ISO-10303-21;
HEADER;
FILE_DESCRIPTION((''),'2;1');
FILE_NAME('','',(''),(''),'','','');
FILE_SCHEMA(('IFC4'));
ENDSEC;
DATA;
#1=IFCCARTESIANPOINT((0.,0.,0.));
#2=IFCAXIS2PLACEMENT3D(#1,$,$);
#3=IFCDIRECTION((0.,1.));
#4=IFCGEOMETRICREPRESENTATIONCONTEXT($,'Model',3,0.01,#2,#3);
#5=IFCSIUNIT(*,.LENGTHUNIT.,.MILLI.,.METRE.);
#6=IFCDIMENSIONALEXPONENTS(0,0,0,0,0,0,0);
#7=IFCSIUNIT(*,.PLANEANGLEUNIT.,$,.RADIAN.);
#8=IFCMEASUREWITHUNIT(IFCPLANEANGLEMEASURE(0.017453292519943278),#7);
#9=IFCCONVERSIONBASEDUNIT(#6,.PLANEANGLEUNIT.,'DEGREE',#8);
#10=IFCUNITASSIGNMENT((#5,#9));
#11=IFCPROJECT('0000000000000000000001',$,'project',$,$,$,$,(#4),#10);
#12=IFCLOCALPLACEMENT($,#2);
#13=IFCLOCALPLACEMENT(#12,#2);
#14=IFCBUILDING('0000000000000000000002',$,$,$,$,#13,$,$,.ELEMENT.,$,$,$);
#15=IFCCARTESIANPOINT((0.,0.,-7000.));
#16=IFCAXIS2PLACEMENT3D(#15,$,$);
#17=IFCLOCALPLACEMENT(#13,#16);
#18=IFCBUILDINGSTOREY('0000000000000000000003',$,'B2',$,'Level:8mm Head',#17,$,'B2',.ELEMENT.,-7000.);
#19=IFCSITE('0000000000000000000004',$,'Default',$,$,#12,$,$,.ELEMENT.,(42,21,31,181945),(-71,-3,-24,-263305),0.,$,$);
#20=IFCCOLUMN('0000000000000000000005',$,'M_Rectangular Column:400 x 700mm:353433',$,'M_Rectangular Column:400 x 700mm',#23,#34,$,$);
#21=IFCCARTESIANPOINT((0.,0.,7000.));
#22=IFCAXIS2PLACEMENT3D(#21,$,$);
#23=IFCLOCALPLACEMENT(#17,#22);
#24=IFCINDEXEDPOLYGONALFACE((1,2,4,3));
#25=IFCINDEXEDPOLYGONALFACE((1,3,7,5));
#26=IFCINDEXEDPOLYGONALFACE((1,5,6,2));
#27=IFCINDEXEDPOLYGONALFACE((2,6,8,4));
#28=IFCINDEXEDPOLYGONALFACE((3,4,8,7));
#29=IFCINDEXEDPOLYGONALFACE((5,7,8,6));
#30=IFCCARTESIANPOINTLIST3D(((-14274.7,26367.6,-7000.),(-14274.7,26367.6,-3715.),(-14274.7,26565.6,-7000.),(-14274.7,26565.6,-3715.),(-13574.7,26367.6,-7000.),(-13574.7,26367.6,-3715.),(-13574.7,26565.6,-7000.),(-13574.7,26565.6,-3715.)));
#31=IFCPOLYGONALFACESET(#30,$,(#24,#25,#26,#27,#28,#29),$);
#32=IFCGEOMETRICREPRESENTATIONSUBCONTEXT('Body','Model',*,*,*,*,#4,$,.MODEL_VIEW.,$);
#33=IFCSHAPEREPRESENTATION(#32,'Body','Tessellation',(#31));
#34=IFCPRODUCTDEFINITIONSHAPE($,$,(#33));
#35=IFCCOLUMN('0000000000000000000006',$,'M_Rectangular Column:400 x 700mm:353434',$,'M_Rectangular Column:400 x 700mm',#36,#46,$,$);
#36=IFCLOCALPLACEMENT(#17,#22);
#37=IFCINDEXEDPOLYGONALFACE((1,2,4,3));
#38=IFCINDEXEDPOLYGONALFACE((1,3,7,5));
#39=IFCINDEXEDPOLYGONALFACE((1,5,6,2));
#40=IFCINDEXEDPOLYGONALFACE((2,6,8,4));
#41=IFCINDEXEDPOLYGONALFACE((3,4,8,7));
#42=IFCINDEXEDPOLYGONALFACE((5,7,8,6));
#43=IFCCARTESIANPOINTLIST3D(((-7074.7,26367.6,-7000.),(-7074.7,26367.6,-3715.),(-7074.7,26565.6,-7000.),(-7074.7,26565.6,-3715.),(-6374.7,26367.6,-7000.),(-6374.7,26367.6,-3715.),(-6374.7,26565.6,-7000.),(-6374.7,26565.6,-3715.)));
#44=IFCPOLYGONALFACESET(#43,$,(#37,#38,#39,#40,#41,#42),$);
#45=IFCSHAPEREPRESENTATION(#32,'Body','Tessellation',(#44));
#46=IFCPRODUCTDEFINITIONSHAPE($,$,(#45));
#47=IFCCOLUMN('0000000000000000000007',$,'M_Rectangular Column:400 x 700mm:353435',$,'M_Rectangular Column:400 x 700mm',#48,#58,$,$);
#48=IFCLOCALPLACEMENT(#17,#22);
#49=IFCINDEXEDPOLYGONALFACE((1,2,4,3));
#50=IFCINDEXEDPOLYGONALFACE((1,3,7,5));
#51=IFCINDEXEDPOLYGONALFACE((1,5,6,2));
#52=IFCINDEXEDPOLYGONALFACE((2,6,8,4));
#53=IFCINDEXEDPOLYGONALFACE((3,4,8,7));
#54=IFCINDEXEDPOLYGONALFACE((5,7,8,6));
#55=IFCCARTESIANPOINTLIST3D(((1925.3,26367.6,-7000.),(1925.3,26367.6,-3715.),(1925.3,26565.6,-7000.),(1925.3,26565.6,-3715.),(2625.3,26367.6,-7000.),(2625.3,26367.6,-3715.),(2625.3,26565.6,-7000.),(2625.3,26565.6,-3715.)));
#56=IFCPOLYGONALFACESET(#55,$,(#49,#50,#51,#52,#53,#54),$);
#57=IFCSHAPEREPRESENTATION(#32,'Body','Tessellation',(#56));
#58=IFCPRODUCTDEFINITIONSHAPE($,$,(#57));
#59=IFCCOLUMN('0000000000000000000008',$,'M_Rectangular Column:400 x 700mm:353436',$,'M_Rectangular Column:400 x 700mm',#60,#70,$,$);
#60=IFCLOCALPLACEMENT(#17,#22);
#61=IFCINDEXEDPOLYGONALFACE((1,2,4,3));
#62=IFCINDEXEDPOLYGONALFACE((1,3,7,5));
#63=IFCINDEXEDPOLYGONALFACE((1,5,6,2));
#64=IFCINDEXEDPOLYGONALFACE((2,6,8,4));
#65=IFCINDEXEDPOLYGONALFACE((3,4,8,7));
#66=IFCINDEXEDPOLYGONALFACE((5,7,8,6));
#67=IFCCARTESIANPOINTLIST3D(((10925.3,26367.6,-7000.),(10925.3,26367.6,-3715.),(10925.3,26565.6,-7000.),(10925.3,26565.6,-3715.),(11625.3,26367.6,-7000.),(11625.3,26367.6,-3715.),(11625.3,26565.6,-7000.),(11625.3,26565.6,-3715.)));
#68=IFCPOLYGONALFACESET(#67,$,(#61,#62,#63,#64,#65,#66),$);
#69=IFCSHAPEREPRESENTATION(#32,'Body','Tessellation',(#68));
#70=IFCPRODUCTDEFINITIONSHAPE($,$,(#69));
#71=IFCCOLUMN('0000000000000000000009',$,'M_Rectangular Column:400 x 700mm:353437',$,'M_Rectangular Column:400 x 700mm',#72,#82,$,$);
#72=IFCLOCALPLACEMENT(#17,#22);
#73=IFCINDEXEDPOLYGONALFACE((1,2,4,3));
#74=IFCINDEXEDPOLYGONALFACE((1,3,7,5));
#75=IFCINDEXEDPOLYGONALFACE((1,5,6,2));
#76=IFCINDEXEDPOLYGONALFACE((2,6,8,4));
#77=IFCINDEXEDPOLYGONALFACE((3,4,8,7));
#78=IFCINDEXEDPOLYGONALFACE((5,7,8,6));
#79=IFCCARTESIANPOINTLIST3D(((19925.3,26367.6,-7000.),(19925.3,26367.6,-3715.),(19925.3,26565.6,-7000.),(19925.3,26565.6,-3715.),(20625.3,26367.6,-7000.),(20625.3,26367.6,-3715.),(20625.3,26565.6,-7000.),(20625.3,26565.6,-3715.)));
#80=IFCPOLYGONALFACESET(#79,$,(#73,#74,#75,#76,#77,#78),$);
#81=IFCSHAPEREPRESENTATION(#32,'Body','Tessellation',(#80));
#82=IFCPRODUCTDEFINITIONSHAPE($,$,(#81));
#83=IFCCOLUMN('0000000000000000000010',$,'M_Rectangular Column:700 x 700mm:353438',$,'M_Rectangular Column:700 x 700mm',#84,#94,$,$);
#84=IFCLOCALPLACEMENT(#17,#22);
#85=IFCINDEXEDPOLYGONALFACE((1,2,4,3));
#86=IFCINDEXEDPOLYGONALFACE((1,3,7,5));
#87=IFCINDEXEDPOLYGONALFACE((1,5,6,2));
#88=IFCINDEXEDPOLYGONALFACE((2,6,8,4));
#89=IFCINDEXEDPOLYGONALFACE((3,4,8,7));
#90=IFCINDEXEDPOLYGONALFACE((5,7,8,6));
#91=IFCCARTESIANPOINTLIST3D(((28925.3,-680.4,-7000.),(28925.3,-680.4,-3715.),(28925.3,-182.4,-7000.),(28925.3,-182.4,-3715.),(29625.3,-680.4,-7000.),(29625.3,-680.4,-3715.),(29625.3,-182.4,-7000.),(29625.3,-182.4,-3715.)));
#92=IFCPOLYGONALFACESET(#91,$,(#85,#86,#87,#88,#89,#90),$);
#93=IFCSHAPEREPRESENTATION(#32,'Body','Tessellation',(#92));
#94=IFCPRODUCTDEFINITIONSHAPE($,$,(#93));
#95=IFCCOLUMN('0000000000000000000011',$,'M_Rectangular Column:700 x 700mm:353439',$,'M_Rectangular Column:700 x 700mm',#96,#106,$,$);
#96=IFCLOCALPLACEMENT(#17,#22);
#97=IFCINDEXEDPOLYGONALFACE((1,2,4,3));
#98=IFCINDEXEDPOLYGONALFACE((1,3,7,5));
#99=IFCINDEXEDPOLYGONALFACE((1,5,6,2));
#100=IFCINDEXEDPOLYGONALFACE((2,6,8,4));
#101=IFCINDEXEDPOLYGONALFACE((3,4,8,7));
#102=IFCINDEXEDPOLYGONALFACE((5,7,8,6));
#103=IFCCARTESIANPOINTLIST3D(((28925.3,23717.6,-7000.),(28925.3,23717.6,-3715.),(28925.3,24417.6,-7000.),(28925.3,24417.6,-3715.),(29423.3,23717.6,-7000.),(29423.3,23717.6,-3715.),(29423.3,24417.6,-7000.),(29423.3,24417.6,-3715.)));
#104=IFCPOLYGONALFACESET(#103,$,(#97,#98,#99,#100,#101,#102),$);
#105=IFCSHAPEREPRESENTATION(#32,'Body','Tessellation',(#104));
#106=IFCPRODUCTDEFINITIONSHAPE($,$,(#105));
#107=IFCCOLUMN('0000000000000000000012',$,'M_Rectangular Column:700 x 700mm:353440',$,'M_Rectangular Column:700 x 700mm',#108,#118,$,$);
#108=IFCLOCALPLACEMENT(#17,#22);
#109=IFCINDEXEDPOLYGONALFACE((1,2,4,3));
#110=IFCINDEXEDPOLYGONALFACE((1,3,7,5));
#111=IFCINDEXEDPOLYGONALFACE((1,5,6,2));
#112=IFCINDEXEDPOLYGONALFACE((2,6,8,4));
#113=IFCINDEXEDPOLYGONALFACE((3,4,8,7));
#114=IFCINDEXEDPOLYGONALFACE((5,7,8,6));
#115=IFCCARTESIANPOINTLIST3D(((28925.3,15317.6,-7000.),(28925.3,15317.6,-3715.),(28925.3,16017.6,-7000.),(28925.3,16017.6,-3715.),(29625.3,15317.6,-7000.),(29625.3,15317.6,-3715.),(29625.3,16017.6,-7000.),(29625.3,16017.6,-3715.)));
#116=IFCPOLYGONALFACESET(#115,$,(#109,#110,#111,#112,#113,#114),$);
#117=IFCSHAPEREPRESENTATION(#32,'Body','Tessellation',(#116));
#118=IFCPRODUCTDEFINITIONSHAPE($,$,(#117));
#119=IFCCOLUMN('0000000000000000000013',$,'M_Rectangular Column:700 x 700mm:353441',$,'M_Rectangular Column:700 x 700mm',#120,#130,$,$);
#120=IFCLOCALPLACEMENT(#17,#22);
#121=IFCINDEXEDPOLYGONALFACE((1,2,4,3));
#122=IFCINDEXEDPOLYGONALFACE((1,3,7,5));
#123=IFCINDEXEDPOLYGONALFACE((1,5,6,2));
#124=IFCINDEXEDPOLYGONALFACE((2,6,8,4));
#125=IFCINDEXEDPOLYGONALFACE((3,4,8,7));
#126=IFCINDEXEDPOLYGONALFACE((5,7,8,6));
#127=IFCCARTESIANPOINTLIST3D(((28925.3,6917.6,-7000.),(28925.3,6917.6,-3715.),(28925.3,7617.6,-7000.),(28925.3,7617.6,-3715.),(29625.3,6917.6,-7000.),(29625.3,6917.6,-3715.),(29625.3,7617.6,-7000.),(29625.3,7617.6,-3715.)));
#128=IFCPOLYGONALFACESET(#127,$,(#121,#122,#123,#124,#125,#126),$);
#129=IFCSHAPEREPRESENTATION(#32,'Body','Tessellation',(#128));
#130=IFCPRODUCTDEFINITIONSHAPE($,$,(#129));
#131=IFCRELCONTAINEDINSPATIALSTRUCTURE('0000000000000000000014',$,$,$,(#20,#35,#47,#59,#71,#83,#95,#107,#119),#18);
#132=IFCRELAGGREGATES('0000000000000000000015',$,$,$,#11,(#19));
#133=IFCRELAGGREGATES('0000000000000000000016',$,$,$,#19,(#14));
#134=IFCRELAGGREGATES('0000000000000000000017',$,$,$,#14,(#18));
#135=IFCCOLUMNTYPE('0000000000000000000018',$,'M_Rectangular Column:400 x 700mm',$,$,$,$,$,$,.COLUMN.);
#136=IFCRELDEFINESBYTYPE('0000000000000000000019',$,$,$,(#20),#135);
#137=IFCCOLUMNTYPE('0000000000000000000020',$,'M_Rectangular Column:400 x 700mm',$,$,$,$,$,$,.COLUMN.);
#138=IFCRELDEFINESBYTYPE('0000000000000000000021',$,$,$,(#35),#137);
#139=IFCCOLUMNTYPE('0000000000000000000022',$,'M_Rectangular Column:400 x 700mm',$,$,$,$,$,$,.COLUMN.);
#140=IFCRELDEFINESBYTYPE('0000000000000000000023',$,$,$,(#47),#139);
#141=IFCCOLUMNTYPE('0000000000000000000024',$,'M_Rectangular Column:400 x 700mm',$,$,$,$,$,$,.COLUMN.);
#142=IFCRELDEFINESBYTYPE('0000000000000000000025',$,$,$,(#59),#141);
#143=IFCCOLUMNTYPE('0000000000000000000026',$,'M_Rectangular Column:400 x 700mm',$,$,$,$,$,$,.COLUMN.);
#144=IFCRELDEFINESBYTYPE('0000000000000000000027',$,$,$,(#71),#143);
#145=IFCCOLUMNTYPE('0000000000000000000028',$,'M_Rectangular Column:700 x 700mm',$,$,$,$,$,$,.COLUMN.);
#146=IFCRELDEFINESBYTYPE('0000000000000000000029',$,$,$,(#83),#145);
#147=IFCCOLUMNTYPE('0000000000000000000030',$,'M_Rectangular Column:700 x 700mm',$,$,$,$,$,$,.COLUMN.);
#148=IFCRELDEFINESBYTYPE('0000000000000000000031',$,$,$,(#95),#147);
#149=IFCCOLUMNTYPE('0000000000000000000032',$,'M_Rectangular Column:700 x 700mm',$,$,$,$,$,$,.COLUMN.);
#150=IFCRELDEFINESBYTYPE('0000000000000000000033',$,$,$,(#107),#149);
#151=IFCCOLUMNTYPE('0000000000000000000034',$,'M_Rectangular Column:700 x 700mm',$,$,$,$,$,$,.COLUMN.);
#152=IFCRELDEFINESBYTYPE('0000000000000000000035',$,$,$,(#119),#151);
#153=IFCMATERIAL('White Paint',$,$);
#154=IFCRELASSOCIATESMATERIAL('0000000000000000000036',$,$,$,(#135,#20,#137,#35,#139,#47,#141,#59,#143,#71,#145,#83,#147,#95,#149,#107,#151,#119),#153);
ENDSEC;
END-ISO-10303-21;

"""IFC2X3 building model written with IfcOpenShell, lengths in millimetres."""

from ifc_helpers import new_model, entity, si_unit, converted_unit, direction, frame, frame_2d, origin, origin_2d_with_axis, place, context, subcontext, project, spatial, rectangle, extrude, source, transform, mapped, material, type_object, type_shapes, element, save


model = new_model("IFC2X3")

# Units and contexts
model_context = context("Model", 3, precision=0.01, world=origin(), true_north=direction((0.0, 1.0)))
body_context = subcontext(model_context, "Body", "Model", "MODEL_VIEW")
ifc_project = project(units=[si_unit("LENGTHUNIT", "METRE", prefix="MILLI"), converted_unit("PLANEANGLEUNIT", "DEGREE", entity("IfcPlaneAngleMeasure", 0.017453292519943278), si_unit("PLANEANGLEUNIT", "RADIAN"), dimensions=[0, 0, 0, 0, 0, 0, 0])], contexts=[model_context])

# Site, building, storey
site_placement = place(None, origin())
site = spatial("IfcSite", under=ifc_project, at=site_placement, Name="Default", CompositionType="ELEMENT", RefLatitude=(42, 21, 31, 181945), RefLongitude=(-71, -3, -24, -263305), RefElevation=0.0)
building_placement = place(site_placement, origin())
building = spatial("IfcBuilding", under=site, at=building_placement, CompositionType="ELEMENT")
storey_placement = place(building_placement, frame((0.0, 0.0, -7000.0)))
storey = spatial("IfcBuildingStorey", under=building, at=storey_placement, Name="B2", ObjectType="Level:8mm Head", LongName="B2", CompositionType="ELEMENT", Elevation=-7000.0)

# Columns
ifc_material_1 = material(Name="White Paint")
column_type_1 = type_object("IfcColumnType", Name="M_Rectangular Column:400 x 700mm", PredefinedType="COLUMN", material=ifc_material_1)
shared_shape_1 = source(origin(), body_context, "Body", "SweptSolid", [
    extrude(rectangle(XDim=3285.0, YDim=198.0, at=origin_2d_with_axis()), frame((-14274.7, 26466.6, -5357.5), z_axis=(1.0, 0.0, 0.0), x_axis=(0.0, 0.0, 1.0)), (0.0, 0.0, 1.0), 700.0),
])
type_shapes(column_type_1, [shared_shape_1])
column_1_placement = place(storey_placement, frame((0.0, 0.0, 7000.0)))
element("IfcColumn", 1, at=column_1_placement, inside=storey, type_object=column_type_1, material=ifc_material_1, Name="M_Rectangular Column:400 x 700mm:353433", ObjectType="M_Rectangular Column:400 x 700mm", context=body_context, shape_type="MappedRepresentation", body=[
    mapped(shared_shape_1, transform((0.0, 0.0, 0.0), scale=1.0)),
])
column_type_2 = type_object("IfcColumnType", Name="M_Rectangular Column:400 x 700mm", PredefinedType="COLUMN", material=ifc_material_1)
shared_shape_2 = source(origin(), body_context, "Body", "SweptSolid", [
    extrude(rectangle(XDim=3285.0, YDim=198.0, at=frame_2d((0.0, 0.0), x_axis=(1.0, 0.0))), frame((-7074.7, 26466.6, -5357.5), z_axis=(1.0, 0.0, 0.0), x_axis=(0.0, 0.0, 1.0)), (0.0, 0.0, 1.0), 700.0),
])
type_shapes(column_type_2, [shared_shape_2])
column_2_placement = place(storey_placement, frame((0.0, 0.0, 7000.0)))
element("IfcColumn", 2, at=column_2_placement, inside=storey, type_object=column_type_2, material=ifc_material_1, Name="M_Rectangular Column:400 x 700mm:353434", ObjectType="M_Rectangular Column:400 x 700mm", context=body_context, shape_type="MappedRepresentation", body=[
    mapped(shared_shape_2, transform((0.0, 0.0, 0.0), scale=1.0)),
])
column_type_3 = type_object("IfcColumnType", Name="M_Rectangular Column:400 x 700mm", PredefinedType="COLUMN", material=ifc_material_1)
shared_shape_3 = source(origin(), body_context, "Body", "SweptSolid", [
    extrude(rectangle(XDim=3285.0, YDim=198.0, at=frame_2d((0.0, 0.0), x_axis=(1.0, 0.0))), frame((1925.3, 26466.6, -5357.5), z_axis=(1.0, 0.0, 0.0), x_axis=(0.0, 0.0, 1.0)), (0.0, 0.0, 1.0), 700.0),
])
type_shapes(column_type_3, [shared_shape_3])
column_3_placement = place(storey_placement, frame((0.0, 0.0, 7000.0)))
element("IfcColumn", 3, at=column_3_placement, inside=storey, type_object=column_type_3, material=ifc_material_1, Name="M_Rectangular Column:400 x 700mm:353435", ObjectType="M_Rectangular Column:400 x 700mm", context=body_context, shape_type="MappedRepresentation", body=[
    mapped(shared_shape_3, transform((0.0, 0.0, 0.0), scale=1.0)),
])
column_type_4 = type_object("IfcColumnType", Name="M_Rectangular Column:400 x 700mm", PredefinedType="COLUMN", material=ifc_material_1)
shared_shape_4 = source(origin(), body_context, "Body", "SweptSolid", [
    extrude(rectangle(XDim=3285.0, YDim=198.0, at=frame_2d((0.0, 0.0), x_axis=(1.0, 0.0))), frame((10925.3, 26466.6, -5357.5), z_axis=(1.0, 0.0, 0.0), x_axis=(0.0, 0.0, 1.0)), (0.0, 0.0, 1.0), 700.0),
])
type_shapes(column_type_4, [shared_shape_4])
column_4_placement = place(storey_placement, frame((0.0, 0.0, 7000.0)))
element("IfcColumn", 4, at=column_4_placement, inside=storey, type_object=column_type_4, material=ifc_material_1, Name="M_Rectangular Column:400 x 700mm:353436", ObjectType="M_Rectangular Column:400 x 700mm", context=body_context, shape_type="MappedRepresentation", body=[
    mapped(shared_shape_4, transform((0.0, 0.0, 0.0), scale=1.0)),
])
column_type_5 = type_object("IfcColumnType", Name="M_Rectangular Column:400 x 700mm", PredefinedType="COLUMN", material=ifc_material_1)
shared_shape_5 = source(origin(), body_context, "Body", "SweptSolid", [
    extrude(rectangle(XDim=3285.0, YDim=198.0, at=frame_2d((0.0, 0.0), x_axis=(1.0, 0.0))), frame((19925.3, 26466.6, -5357.5), z_axis=(1.0, 0.0, 0.0), x_axis=(0.0, 0.0, 1.0)), (0.0, 0.0, 1.0), 700.0),
])
type_shapes(column_type_5, [shared_shape_5])
column_5_placement = place(storey_placement, frame((0.0, 0.0, 7000.0)))
element("IfcColumn", 5, at=column_5_placement, inside=storey, type_object=column_type_5, material=ifc_material_1, Name="M_Rectangular Column:400 x 700mm:353437", ObjectType="M_Rectangular Column:400 x 700mm", context=body_context, shape_type="MappedRepresentation", body=[
    mapped(shared_shape_5, transform((0.0, 0.0, 0.0), scale=1.0)),
])
column_type_6 = type_object("IfcColumnType", Name="M_Rectangular Column:700 x 700mm", PredefinedType="COLUMN", material=ifc_material_1)
shared_shape_6 = source(origin(), body_context, "Body", "SweptSolid", [
    extrude(rectangle(XDim=3285.0, YDim=498.0, at=origin_2d_with_axis()), frame((28925.3, -431.4, -5357.5), z_axis=(1.0, 0.0, 0.0), x_axis=(0.0, 0.0, 1.0)), (0.0, 0.0, 1.0), 700.0),
])
type_shapes(column_type_6, [shared_shape_6])
column_6_placement = place(storey_placement, frame((0.0, 0.0, 7000.0)))
element("IfcColumn", 6, at=column_6_placement, inside=storey, type_object=column_type_6, material=ifc_material_1, Name="M_Rectangular Column:700 x 700mm:353438", ObjectType="M_Rectangular Column:700 x 700mm", context=body_context, shape_type="MappedRepresentation", body=[
    mapped(shared_shape_6, transform((0.0, 0.0, 0.0), scale=1.0)),
])
column_type_7 = type_object("IfcColumnType", Name="M_Rectangular Column:700 x 700mm", PredefinedType="COLUMN", material=ifc_material_1)
shared_shape_7 = source(origin(), body_context, "Body", "SweptSolid", [
    extrude(rectangle(XDim=3285.0, YDim=498.0, at=frame_2d((0.0, 0.0), x_axis=(1.0, 0.0))), frame((29174.3, 23717.6, -5357.5), z_axis=(0.0, 1.0, 0.0), x_axis=(0.0, 0.0, 1.0)), (0.0, 0.0, 1.0), 700.0),
])
type_shapes(column_type_7, [shared_shape_7])
column_7_placement = place(storey_placement, frame((0.0, 0.0, 7000.0)))
element("IfcColumn", 7, at=column_7_placement, inside=storey, type_object=column_type_7, material=ifc_material_1, Name="M_Rectangular Column:700 x 700mm:353439", ObjectType="M_Rectangular Column:700 x 700mm", context=body_context, shape_type="MappedRepresentation", body=[
    mapped(shared_shape_7, transform((0.0, 0.0, 0.0), scale=1.0)),
])
column_type_8 = type_object("IfcColumnType", Name="M_Rectangular Column:700 x 700mm", PredefinedType="COLUMN", material=ifc_material_1)
shared_shape_8 = source(origin(), body_context, "Body", "SweptSolid", [
    extrude(rectangle(XDim=700.0, YDim=700.0, at=frame_2d((0.0, 0.0), x_axis=(1.0, 0.0))), frame((29275.3, 15667.6, -7000.0), z_axis=(0.0, 0.0, 1.0), x_axis=(-1.0, 0.0, 0.0)), (0.0, 0.0, 1.0), 3285.0),
])
type_shapes(column_type_8, [shared_shape_8])
column_8_placement = place(storey_placement, frame((0.0, 0.0, 7000.0)))
element("IfcColumn", 8, at=column_8_placement, inside=storey, type_object=column_type_8, material=ifc_material_1, Name="M_Rectangular Column:700 x 700mm:353440", ObjectType="M_Rectangular Column:700 x 700mm", context=body_context, shape_type="MappedRepresentation", body=[
    mapped(shared_shape_8, transform((0.0, 0.0, 0.0), scale=1.0)),
])
column_type_9 = type_object("IfcColumnType", Name="M_Rectangular Column:700 x 700mm", PredefinedType="COLUMN", material=ifc_material_1)
shared_shape_9 = source(origin(), body_context, "Body", "SweptSolid", [
    extrude(rectangle(XDim=700.0, YDim=700.0, at=frame_2d((0.0, 0.0), x_axis=(1.0, 0.0))), frame((29275.3, 7267.6, -7000.0), z_axis=(0.0, 0.0, 1.0), x_axis=(-1.0, 0.0, 0.0)), (0.0, 0.0, 1.0), 3285.0),
])
type_shapes(column_type_9, [shared_shape_9])
column_9_placement = place(storey_placement, frame((0.0, 0.0, 7000.0)))
element("IfcColumn", 9, at=column_9_placement, inside=storey, type_object=column_type_9, material=ifc_material_1, Name="M_Rectangular Column:700 x 700mm:353441", ObjectType="M_Rectangular Column:700 x 700mm", context=body_context, shape_type="MappedRepresentation", body=[
    mapped(shared_shape_9, transform((0.0, 0.0, 0.0), scale=1.0)),
])

save(model, "model.ifc")
